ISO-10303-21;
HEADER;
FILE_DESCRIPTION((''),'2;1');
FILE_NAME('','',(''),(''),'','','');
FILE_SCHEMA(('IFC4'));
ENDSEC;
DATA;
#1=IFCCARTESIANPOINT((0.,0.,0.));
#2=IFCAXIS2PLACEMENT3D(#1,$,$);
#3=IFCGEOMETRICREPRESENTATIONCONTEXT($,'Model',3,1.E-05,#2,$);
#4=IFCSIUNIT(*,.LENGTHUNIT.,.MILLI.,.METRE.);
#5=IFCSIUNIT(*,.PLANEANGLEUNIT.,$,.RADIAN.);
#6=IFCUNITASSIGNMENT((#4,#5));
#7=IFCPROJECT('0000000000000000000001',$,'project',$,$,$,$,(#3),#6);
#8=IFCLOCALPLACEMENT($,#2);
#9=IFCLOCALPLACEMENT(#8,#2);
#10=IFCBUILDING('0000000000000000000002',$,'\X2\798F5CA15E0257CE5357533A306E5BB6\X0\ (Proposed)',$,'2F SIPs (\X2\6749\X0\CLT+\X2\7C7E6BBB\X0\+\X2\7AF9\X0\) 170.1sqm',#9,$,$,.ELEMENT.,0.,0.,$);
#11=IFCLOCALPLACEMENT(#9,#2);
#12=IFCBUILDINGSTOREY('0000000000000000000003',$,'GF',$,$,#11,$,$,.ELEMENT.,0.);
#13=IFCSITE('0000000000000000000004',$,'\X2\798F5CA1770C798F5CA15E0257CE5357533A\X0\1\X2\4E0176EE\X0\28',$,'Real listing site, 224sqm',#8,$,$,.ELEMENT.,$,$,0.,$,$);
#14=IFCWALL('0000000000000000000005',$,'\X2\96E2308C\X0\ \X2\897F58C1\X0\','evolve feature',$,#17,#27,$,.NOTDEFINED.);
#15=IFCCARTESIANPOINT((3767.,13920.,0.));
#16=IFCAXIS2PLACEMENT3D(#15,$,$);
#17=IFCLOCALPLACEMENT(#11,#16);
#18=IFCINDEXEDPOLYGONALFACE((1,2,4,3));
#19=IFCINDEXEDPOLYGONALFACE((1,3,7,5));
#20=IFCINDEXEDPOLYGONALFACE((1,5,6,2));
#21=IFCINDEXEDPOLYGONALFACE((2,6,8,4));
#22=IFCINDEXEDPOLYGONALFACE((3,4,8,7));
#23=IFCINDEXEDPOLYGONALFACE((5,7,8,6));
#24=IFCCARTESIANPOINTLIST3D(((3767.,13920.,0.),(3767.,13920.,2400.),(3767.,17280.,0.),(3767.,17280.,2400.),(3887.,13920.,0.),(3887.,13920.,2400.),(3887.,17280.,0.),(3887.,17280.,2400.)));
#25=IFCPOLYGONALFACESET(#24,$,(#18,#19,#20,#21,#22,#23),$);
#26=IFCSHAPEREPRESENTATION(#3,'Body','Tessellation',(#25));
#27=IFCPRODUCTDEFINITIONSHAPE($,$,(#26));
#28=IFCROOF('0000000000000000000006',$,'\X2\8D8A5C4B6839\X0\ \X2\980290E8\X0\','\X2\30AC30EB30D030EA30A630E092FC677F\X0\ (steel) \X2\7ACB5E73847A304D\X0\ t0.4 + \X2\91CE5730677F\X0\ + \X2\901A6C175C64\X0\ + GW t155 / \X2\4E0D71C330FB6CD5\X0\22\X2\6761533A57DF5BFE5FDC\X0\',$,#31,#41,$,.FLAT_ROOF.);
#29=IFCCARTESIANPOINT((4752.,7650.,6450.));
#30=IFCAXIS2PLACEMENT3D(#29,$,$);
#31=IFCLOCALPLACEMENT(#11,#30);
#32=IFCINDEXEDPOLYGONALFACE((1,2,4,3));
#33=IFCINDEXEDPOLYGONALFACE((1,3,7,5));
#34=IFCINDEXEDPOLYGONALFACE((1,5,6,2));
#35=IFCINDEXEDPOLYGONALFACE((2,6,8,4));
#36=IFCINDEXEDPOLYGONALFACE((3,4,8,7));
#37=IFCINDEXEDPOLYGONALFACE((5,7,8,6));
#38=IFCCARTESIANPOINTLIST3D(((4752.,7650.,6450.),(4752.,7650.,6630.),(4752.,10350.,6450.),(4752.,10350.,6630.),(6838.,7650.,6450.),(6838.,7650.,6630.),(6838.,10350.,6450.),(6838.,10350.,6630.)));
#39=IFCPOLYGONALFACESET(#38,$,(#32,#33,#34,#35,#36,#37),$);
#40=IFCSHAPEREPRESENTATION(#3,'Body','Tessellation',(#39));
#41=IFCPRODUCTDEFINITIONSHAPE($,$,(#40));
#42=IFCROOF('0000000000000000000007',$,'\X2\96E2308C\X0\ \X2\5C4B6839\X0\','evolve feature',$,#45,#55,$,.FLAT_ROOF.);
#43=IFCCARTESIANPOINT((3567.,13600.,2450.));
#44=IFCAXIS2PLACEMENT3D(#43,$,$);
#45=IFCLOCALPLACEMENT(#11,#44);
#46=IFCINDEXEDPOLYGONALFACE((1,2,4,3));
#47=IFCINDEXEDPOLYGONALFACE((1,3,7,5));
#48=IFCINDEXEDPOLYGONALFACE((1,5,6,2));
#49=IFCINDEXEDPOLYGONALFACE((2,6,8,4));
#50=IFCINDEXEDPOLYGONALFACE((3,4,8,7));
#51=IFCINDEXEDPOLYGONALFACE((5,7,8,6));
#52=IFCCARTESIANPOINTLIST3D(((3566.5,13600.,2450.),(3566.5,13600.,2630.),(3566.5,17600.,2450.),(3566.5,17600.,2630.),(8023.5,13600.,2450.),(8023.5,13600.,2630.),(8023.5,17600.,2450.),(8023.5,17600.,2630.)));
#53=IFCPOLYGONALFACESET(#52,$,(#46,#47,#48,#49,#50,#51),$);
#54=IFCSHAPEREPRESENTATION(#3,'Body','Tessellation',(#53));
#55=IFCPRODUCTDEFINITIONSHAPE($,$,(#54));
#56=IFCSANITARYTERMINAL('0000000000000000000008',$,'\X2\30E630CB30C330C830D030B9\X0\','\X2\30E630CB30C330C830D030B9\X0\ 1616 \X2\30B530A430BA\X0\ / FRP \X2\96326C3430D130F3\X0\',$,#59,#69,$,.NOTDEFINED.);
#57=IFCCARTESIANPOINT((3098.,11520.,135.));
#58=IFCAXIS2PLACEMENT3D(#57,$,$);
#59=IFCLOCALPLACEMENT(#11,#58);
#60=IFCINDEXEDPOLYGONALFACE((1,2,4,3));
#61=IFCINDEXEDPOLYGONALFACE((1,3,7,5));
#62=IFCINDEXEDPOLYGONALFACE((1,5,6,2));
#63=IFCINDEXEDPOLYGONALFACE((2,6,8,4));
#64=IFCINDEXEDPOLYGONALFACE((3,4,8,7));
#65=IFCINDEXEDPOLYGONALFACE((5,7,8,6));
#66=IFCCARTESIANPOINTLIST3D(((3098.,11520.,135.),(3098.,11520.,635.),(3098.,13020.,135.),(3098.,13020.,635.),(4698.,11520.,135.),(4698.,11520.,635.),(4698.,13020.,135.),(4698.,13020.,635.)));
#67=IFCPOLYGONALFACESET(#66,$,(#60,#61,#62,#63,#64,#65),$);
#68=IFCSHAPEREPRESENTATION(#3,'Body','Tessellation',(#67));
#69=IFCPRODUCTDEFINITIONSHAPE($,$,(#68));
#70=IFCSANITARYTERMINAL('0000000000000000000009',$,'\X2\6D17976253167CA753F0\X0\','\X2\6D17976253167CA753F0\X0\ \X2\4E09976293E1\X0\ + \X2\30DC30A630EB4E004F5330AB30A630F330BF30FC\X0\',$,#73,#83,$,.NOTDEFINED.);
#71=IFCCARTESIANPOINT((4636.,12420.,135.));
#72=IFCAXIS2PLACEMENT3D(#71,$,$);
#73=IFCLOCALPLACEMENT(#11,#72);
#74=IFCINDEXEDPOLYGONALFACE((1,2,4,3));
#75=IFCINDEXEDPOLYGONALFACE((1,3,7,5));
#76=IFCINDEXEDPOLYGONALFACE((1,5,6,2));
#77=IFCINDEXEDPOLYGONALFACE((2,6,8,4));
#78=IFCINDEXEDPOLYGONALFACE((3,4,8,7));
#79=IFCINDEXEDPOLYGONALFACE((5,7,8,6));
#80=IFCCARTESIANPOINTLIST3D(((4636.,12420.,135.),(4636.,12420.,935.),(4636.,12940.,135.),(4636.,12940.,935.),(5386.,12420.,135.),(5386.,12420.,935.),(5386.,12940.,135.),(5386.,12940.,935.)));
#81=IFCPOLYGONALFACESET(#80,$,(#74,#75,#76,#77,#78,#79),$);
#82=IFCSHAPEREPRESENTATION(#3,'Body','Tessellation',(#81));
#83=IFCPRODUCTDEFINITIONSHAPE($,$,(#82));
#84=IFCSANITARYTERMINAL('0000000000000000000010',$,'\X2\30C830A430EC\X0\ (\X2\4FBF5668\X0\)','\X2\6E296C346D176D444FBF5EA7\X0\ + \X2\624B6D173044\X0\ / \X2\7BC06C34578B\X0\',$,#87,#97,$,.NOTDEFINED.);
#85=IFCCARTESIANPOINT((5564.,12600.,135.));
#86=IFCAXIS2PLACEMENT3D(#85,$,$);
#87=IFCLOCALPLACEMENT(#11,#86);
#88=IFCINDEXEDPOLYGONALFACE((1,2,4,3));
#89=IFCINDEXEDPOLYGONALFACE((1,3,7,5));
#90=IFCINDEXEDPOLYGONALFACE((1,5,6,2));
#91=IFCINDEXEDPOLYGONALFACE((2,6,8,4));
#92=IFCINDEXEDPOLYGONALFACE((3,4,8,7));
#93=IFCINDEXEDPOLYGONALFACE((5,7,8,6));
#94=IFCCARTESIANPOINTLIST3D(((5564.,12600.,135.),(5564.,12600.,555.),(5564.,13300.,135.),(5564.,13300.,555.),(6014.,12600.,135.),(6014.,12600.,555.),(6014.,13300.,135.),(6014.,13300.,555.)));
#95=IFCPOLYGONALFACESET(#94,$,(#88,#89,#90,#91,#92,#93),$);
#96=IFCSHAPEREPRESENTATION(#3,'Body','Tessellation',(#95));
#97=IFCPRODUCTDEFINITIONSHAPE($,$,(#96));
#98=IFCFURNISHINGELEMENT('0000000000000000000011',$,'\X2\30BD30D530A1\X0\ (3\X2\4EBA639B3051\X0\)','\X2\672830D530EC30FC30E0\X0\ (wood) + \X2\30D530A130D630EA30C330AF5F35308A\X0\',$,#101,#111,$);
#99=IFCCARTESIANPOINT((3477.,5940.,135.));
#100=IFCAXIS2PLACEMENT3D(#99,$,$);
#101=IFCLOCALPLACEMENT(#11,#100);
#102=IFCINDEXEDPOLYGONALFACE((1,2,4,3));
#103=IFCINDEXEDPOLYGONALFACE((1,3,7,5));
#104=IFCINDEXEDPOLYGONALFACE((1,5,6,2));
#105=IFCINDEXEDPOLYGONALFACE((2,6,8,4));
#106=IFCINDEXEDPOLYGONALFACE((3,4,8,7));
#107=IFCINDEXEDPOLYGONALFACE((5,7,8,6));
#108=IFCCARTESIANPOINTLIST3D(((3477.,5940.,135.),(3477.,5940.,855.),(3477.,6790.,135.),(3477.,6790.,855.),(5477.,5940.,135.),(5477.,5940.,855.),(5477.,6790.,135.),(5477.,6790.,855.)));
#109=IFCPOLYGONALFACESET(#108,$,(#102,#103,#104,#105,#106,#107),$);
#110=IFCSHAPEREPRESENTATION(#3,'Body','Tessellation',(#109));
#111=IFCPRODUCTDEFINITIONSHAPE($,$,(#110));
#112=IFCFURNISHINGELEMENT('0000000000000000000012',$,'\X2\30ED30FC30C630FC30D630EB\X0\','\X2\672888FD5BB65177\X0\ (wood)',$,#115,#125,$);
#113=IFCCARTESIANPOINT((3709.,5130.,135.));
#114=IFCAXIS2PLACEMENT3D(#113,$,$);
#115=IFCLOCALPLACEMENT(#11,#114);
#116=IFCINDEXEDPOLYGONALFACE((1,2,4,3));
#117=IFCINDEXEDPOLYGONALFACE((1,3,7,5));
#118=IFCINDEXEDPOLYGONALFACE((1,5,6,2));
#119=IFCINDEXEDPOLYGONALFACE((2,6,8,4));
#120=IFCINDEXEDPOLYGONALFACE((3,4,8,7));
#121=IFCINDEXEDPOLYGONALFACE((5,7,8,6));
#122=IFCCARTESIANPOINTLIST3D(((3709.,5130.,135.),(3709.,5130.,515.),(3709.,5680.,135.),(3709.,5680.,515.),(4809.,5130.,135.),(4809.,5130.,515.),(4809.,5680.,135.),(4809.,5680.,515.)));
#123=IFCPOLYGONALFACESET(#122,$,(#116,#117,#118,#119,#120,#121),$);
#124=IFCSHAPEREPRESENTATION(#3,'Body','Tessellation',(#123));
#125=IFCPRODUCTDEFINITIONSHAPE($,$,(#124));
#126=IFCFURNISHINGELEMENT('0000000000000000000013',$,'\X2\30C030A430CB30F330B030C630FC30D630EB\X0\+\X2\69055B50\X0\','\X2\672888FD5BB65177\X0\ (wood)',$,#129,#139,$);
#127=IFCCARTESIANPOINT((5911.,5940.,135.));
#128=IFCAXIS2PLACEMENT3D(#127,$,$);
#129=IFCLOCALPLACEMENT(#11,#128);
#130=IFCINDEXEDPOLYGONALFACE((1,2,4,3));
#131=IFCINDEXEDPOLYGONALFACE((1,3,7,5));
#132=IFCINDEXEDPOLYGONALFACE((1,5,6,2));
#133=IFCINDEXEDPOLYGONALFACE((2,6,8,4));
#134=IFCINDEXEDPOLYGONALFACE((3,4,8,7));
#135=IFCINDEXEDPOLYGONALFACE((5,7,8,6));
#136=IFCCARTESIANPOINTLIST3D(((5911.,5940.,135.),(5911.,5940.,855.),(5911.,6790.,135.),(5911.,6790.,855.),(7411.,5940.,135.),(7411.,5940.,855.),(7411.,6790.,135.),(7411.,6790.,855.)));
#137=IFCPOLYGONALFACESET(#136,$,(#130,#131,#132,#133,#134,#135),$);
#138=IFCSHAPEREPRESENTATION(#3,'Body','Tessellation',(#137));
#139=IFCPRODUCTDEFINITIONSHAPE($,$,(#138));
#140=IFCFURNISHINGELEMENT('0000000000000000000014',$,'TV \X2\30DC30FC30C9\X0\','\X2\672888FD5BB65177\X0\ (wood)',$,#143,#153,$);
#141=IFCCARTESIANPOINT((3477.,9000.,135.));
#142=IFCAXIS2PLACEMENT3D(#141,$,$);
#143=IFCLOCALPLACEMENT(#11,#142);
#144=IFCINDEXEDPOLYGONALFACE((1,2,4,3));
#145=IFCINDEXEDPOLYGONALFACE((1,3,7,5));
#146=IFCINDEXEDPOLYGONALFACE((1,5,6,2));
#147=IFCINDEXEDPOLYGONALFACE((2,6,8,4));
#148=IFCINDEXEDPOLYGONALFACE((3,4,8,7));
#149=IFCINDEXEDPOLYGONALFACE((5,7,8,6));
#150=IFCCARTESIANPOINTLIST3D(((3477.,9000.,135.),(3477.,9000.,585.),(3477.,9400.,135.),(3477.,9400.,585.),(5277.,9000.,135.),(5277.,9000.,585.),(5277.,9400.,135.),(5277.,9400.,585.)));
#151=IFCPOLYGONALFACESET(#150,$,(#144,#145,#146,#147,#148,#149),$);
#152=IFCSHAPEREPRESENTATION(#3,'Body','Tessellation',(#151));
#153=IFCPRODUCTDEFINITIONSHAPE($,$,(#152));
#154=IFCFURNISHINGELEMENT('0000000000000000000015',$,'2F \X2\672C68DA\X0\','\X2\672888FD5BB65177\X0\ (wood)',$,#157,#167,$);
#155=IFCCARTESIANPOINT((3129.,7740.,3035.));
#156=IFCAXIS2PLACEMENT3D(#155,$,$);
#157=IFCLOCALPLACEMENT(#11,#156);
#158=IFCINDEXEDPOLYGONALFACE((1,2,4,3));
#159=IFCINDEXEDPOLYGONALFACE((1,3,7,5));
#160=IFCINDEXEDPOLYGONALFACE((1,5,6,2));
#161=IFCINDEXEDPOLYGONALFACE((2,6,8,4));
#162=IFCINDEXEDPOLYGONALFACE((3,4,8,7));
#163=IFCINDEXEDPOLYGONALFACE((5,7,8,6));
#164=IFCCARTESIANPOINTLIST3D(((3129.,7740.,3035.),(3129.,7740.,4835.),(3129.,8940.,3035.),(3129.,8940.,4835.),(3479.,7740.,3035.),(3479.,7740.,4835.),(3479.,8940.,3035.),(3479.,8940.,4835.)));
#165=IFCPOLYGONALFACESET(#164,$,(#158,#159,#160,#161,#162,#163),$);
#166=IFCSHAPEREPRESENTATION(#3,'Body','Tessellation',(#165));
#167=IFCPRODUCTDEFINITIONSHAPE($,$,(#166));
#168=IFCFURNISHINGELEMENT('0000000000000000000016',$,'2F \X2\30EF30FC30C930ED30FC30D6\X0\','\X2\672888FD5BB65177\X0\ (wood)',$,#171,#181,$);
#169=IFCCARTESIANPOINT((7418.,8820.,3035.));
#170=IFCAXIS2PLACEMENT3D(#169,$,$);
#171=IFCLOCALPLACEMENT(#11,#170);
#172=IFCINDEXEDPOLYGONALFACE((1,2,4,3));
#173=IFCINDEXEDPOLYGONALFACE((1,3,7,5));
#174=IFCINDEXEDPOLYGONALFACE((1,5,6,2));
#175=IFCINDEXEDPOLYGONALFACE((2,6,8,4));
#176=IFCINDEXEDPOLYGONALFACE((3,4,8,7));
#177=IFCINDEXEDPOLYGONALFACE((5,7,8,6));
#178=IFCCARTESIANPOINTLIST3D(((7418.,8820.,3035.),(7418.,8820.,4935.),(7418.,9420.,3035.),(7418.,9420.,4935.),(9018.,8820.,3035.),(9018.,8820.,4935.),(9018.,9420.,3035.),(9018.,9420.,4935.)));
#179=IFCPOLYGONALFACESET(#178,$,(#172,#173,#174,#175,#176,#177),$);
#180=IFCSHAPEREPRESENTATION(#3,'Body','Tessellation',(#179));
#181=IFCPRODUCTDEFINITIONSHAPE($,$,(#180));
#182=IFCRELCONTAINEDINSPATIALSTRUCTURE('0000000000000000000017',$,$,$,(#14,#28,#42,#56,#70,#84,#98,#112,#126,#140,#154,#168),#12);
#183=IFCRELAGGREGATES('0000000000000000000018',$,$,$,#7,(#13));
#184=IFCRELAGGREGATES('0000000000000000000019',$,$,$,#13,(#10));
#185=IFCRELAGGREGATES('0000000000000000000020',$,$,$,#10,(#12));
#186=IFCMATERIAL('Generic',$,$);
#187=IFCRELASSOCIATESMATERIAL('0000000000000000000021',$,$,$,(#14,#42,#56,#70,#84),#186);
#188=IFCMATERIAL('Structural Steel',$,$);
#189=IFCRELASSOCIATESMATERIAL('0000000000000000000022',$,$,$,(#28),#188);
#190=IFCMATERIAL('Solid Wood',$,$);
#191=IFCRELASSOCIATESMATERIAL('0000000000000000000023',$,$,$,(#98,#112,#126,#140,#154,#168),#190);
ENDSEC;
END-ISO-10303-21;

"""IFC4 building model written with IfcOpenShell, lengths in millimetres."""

from ifc_helpers import new_model, si_unit, frame, frame_2d, origin, place, context, project, spatial, rectangle, extrude, material, element, save


model = new_model("IFC4")

# Units and contexts
model_context = context("Model", 3, precision=1e-05, world=origin())
ifc_project = project(units=[si_unit("LENGTHUNIT", "METRE", prefix="MILLI"), si_unit("PLANEANGLEUNIT", "RADIAN")], contexts=[model_context])

# Site, building, storey
site_placement = place(None, origin())
site = spatial("IfcSite", under=ifc_project, at=site_placement, Name="福岡県福岡市城南区1丁目28", ObjectType="Real listing site, 224sqm", CompositionType="ELEMENT", RefElevation=0.0)
building_placement = place(site_placement, origin())
building = spatial("IfcBuilding", under=site, at=building_placement, Name="福岡市城南区の家 (Proposed)", ObjectType="2F SIPs (杉CLT+籾殻+竹) 170.1sqm", CompositionType="ELEMENT", ElevationOfRefHeight=0.0, ElevationOfTerrain=0.0)
storey_placement = place(building_placement, origin())
storey = spatial("IfcBuildingStorey", under=building, at=storey_placement, Name="GF", CompositionType="ELEMENT", Elevation=0.0)

# Shared definitions
ifc_material_1 = material(Name="Generic")

# Shared definitions
ifc_material_2 = material(Name="Solid Wood")

# Wall
wall_1_placement = place(storey_placement, frame((3767.0, 13920.0, 0.0)))
element("IfcWall", 1, at=wall_1_placement, inside=storey, material=ifc_material_1, Name="離れ 西壁", Description="evolve feature", PredefinedType="NOTDEFINED", context=model_context, shape_type="SweptSolid", body=[
    extrude(rectangle(XDim=120.0, YDim=3360.0, at=frame_2d((60.0, 1680.0))), frame((3767.0, 13920.0, 0.0)), (0.0, 0.0, 1.0), 2400.0),
])

# Roofs
ifc_material_3 = material(Name="Structural Steel")
roof_1_placement = place(storey_placement, frame((4752.0, 7650.0, 6450.0)))
element("IfcRoof", 2, at=roof_1_placement, inside=storey, material=ifc_material_3, Name="越屋根 頂部", Description="ガルバリウム鋼板 (steel) 立平葺き t0.4 + 野地板 + 通気層 + GW t155 / 不燃・法22条区域対応", PredefinedType="FLAT_ROOF", context=model_context, shape_type="SweptSolid", body=[
    extrude(rectangle(XDim=2086.0, YDim=2700.0, at=frame_2d((1043.0, 1350.0))), frame((4752.0, 7650.0, 6450.0)), (0.0, 0.0, 1.0), 180.0),
])
roof_2_placement = place(storey_placement, frame((3567.0, 13600.0, 2450.0)))
element("IfcRoof", 3, at=roof_2_placement, inside=storey, material=ifc_material_1, Name="離れ 屋根", Description="evolve feature", PredefinedType="FLAT_ROOF", context=model_context, shape_type="SweptSolid", body=[
    extrude(rectangle(XDim=4457.0, YDim=4000.0, at=frame_2d((2228.0, 2000.0))), frame((3567.0, 13600.0, 2450.0)), (0.0, 0.0, 1.0), 180.0),
])

# Sanitary terminals
sanitary_terminal_1_placement = place(storey_placement, frame((3098.0, 11520.0, 135.0)))
element("IfcSanitaryTerminal", 4, at=sanitary_terminal_1_placement, inside=storey, material=ifc_material_1, Name="ユニットバス", Description="ユニットバス 1616 サイズ / FRP 防水パン", PredefinedType="NOTDEFINED", context=model_context, shape_type="SweptSolid", body=[
    extrude(rectangle(XDim=1600.0, YDim=1500.0, at=frame_2d((800.0, 750.0))), frame((3098.0, 11520.0, 135.0)), (0.0, 0.0, 1.0), 500.0),
])
sanitary_terminal_2_placement = place(storey_placement, frame((4636.0, 12420.0, 135.0)))
element("IfcSanitaryTerminal", 5, at=sanitary_terminal_2_placement, inside=storey, material=ifc_material_1, Name="洗面化粧台", Description="洗面化粧台 三面鏡 + ボウル一体カウンター", PredefinedType="NOTDEFINED", context=model_context, shape_type="SweptSolid", body=[
    extrude(rectangle(XDim=750.0, YDim=520.0, at=frame_2d((375.0, 260.0))), frame((4636.0, 12420.0, 135.0)), (0.0, 0.0, 1.0), 800.0),
])
sanitary_terminal_3_placement = place(storey_placement, frame((5564.0, 12600.0, 135.0)))
element("IfcSanitaryTerminal", 6, at=sanitary_terminal_3_placement, inside=storey, material=ifc_material_1, Name="トイレ (便器)", Description="温水洗浄便座 + 手洗い / 節水型", PredefinedType="NOTDEFINED", context=model_context, shape_type="SweptSolid", body=[
    extrude(rectangle(XDim=450.0, YDim=700.0, at=frame_2d((225.0, 350.0))), frame((5564.0, 12600.0, 135.0)), (0.0, 0.0, 1.0), 420.0),
])

# Furnishing elements
furnishing_1_placement = place(storey_placement, frame((3477.0, 5940.0, 135.0)))
element("IfcFurnishingElement", 7, at=furnishing_1_placement, inside=storey, material=ifc_material_2, Name="ソファ (3人掛け)", Description="木フレーム (wood) + ファブリック張り", context=model_context, shape_type="SweptSolid", body=[
    extrude(rectangle(XDim=2000.0, YDim=850.0, at=frame_2d((1000.0, 425.0))), frame((3477.0, 5940.0, 135.0)), (0.0, 0.0, 1.0), 720.0),
])
furnishing_2_placement = place(storey_placement, frame((3709.0, 5130.0, 135.0)))
element("IfcFurnishingElement", 8, at=furnishing_2_placement, inside=storey, material=ifc_material_2, Name="ローテーブル", Description="木製家具 (wood)", context=model_context, shape_type="SweptSolid", body=[
    extrude(rectangle(XDim=1100.0, YDim=550.0, at=frame_2d((550.0, 275.0))), frame((3709.0, 5130.0, 135.0)), (0.0, 0.0, 1.0), 380.0),
])
furnishing_3_placement = place(storey_placement, frame((5911.0, 5940.0, 135.0)))
element("IfcFurnishingElement", 9, at=furnishing_3_placement, inside=storey, material=ifc_material_2, Name="ダイニングテーブル+椅子", Description="木製家具 (wood)", context=model_context, shape_type="SweptSolid", body=[
    extrude(rectangle(XDim=1500.0, YDim=850.0, at=frame_2d((750.0, 425.0))), frame((5911.0, 5940.0, 135.0)), (0.0, 0.0, 1.0), 720.0),
])
furnishing_4_placement = place(storey_placement, frame((3477.0, 9000.0, 135.0)))
element("IfcFurnishingElement", 10, at=furnishing_4_placement, inside=storey, material=ifc_material_2, Name="TV ボード", Description="木製家具 (wood)", context=model_context, shape_type="SweptSolid", body=[
    extrude(rectangle(XDim=1800.0, YDim=400.0, at=frame_2d((900.0, 200.0))), frame((3477.0, 9000.0, 135.0)), (0.0, 0.0, 1.0), 450.0),
])
furnishing_5_placement = place(storey_placement, frame((3129.0, 7740.0, 3035.0)))
element("IfcFurnishingElement", 11, at=furnishing_5_placement, inside=storey, material=ifc_material_2, Name="2F 本棚", Description="木製家具 (wood)", context=model_context, shape_type="SweptSolid", body=[
    extrude(rectangle(XDim=350.0, YDim=1200.0, at=frame_2d((175.0, 600.0))), frame((3129.0, 7740.0, 3035.0)), (0.0, 0.0, 1.0), 1800.0),
])
furnishing_6_placement = place(storey_placement, frame((7418.0, 8820.0, 3035.0)))
element("IfcFurnishingElement", 12, at=furnishing_6_placement, inside=storey, material=ifc_material_2, Name="2F ワードローブ", Description="木製家具 (wood)", context=model_context, shape_type="SweptSolid", body=[
    extrude(rectangle(XDim=1600.0, YDim=600.0, at=frame_2d((800.0, 300.0))), frame((7418.0, 8820.0, 3035.0)), (0.0, 0.0, 1.0), 1900.0),
])

save(model, "model.ifc")
